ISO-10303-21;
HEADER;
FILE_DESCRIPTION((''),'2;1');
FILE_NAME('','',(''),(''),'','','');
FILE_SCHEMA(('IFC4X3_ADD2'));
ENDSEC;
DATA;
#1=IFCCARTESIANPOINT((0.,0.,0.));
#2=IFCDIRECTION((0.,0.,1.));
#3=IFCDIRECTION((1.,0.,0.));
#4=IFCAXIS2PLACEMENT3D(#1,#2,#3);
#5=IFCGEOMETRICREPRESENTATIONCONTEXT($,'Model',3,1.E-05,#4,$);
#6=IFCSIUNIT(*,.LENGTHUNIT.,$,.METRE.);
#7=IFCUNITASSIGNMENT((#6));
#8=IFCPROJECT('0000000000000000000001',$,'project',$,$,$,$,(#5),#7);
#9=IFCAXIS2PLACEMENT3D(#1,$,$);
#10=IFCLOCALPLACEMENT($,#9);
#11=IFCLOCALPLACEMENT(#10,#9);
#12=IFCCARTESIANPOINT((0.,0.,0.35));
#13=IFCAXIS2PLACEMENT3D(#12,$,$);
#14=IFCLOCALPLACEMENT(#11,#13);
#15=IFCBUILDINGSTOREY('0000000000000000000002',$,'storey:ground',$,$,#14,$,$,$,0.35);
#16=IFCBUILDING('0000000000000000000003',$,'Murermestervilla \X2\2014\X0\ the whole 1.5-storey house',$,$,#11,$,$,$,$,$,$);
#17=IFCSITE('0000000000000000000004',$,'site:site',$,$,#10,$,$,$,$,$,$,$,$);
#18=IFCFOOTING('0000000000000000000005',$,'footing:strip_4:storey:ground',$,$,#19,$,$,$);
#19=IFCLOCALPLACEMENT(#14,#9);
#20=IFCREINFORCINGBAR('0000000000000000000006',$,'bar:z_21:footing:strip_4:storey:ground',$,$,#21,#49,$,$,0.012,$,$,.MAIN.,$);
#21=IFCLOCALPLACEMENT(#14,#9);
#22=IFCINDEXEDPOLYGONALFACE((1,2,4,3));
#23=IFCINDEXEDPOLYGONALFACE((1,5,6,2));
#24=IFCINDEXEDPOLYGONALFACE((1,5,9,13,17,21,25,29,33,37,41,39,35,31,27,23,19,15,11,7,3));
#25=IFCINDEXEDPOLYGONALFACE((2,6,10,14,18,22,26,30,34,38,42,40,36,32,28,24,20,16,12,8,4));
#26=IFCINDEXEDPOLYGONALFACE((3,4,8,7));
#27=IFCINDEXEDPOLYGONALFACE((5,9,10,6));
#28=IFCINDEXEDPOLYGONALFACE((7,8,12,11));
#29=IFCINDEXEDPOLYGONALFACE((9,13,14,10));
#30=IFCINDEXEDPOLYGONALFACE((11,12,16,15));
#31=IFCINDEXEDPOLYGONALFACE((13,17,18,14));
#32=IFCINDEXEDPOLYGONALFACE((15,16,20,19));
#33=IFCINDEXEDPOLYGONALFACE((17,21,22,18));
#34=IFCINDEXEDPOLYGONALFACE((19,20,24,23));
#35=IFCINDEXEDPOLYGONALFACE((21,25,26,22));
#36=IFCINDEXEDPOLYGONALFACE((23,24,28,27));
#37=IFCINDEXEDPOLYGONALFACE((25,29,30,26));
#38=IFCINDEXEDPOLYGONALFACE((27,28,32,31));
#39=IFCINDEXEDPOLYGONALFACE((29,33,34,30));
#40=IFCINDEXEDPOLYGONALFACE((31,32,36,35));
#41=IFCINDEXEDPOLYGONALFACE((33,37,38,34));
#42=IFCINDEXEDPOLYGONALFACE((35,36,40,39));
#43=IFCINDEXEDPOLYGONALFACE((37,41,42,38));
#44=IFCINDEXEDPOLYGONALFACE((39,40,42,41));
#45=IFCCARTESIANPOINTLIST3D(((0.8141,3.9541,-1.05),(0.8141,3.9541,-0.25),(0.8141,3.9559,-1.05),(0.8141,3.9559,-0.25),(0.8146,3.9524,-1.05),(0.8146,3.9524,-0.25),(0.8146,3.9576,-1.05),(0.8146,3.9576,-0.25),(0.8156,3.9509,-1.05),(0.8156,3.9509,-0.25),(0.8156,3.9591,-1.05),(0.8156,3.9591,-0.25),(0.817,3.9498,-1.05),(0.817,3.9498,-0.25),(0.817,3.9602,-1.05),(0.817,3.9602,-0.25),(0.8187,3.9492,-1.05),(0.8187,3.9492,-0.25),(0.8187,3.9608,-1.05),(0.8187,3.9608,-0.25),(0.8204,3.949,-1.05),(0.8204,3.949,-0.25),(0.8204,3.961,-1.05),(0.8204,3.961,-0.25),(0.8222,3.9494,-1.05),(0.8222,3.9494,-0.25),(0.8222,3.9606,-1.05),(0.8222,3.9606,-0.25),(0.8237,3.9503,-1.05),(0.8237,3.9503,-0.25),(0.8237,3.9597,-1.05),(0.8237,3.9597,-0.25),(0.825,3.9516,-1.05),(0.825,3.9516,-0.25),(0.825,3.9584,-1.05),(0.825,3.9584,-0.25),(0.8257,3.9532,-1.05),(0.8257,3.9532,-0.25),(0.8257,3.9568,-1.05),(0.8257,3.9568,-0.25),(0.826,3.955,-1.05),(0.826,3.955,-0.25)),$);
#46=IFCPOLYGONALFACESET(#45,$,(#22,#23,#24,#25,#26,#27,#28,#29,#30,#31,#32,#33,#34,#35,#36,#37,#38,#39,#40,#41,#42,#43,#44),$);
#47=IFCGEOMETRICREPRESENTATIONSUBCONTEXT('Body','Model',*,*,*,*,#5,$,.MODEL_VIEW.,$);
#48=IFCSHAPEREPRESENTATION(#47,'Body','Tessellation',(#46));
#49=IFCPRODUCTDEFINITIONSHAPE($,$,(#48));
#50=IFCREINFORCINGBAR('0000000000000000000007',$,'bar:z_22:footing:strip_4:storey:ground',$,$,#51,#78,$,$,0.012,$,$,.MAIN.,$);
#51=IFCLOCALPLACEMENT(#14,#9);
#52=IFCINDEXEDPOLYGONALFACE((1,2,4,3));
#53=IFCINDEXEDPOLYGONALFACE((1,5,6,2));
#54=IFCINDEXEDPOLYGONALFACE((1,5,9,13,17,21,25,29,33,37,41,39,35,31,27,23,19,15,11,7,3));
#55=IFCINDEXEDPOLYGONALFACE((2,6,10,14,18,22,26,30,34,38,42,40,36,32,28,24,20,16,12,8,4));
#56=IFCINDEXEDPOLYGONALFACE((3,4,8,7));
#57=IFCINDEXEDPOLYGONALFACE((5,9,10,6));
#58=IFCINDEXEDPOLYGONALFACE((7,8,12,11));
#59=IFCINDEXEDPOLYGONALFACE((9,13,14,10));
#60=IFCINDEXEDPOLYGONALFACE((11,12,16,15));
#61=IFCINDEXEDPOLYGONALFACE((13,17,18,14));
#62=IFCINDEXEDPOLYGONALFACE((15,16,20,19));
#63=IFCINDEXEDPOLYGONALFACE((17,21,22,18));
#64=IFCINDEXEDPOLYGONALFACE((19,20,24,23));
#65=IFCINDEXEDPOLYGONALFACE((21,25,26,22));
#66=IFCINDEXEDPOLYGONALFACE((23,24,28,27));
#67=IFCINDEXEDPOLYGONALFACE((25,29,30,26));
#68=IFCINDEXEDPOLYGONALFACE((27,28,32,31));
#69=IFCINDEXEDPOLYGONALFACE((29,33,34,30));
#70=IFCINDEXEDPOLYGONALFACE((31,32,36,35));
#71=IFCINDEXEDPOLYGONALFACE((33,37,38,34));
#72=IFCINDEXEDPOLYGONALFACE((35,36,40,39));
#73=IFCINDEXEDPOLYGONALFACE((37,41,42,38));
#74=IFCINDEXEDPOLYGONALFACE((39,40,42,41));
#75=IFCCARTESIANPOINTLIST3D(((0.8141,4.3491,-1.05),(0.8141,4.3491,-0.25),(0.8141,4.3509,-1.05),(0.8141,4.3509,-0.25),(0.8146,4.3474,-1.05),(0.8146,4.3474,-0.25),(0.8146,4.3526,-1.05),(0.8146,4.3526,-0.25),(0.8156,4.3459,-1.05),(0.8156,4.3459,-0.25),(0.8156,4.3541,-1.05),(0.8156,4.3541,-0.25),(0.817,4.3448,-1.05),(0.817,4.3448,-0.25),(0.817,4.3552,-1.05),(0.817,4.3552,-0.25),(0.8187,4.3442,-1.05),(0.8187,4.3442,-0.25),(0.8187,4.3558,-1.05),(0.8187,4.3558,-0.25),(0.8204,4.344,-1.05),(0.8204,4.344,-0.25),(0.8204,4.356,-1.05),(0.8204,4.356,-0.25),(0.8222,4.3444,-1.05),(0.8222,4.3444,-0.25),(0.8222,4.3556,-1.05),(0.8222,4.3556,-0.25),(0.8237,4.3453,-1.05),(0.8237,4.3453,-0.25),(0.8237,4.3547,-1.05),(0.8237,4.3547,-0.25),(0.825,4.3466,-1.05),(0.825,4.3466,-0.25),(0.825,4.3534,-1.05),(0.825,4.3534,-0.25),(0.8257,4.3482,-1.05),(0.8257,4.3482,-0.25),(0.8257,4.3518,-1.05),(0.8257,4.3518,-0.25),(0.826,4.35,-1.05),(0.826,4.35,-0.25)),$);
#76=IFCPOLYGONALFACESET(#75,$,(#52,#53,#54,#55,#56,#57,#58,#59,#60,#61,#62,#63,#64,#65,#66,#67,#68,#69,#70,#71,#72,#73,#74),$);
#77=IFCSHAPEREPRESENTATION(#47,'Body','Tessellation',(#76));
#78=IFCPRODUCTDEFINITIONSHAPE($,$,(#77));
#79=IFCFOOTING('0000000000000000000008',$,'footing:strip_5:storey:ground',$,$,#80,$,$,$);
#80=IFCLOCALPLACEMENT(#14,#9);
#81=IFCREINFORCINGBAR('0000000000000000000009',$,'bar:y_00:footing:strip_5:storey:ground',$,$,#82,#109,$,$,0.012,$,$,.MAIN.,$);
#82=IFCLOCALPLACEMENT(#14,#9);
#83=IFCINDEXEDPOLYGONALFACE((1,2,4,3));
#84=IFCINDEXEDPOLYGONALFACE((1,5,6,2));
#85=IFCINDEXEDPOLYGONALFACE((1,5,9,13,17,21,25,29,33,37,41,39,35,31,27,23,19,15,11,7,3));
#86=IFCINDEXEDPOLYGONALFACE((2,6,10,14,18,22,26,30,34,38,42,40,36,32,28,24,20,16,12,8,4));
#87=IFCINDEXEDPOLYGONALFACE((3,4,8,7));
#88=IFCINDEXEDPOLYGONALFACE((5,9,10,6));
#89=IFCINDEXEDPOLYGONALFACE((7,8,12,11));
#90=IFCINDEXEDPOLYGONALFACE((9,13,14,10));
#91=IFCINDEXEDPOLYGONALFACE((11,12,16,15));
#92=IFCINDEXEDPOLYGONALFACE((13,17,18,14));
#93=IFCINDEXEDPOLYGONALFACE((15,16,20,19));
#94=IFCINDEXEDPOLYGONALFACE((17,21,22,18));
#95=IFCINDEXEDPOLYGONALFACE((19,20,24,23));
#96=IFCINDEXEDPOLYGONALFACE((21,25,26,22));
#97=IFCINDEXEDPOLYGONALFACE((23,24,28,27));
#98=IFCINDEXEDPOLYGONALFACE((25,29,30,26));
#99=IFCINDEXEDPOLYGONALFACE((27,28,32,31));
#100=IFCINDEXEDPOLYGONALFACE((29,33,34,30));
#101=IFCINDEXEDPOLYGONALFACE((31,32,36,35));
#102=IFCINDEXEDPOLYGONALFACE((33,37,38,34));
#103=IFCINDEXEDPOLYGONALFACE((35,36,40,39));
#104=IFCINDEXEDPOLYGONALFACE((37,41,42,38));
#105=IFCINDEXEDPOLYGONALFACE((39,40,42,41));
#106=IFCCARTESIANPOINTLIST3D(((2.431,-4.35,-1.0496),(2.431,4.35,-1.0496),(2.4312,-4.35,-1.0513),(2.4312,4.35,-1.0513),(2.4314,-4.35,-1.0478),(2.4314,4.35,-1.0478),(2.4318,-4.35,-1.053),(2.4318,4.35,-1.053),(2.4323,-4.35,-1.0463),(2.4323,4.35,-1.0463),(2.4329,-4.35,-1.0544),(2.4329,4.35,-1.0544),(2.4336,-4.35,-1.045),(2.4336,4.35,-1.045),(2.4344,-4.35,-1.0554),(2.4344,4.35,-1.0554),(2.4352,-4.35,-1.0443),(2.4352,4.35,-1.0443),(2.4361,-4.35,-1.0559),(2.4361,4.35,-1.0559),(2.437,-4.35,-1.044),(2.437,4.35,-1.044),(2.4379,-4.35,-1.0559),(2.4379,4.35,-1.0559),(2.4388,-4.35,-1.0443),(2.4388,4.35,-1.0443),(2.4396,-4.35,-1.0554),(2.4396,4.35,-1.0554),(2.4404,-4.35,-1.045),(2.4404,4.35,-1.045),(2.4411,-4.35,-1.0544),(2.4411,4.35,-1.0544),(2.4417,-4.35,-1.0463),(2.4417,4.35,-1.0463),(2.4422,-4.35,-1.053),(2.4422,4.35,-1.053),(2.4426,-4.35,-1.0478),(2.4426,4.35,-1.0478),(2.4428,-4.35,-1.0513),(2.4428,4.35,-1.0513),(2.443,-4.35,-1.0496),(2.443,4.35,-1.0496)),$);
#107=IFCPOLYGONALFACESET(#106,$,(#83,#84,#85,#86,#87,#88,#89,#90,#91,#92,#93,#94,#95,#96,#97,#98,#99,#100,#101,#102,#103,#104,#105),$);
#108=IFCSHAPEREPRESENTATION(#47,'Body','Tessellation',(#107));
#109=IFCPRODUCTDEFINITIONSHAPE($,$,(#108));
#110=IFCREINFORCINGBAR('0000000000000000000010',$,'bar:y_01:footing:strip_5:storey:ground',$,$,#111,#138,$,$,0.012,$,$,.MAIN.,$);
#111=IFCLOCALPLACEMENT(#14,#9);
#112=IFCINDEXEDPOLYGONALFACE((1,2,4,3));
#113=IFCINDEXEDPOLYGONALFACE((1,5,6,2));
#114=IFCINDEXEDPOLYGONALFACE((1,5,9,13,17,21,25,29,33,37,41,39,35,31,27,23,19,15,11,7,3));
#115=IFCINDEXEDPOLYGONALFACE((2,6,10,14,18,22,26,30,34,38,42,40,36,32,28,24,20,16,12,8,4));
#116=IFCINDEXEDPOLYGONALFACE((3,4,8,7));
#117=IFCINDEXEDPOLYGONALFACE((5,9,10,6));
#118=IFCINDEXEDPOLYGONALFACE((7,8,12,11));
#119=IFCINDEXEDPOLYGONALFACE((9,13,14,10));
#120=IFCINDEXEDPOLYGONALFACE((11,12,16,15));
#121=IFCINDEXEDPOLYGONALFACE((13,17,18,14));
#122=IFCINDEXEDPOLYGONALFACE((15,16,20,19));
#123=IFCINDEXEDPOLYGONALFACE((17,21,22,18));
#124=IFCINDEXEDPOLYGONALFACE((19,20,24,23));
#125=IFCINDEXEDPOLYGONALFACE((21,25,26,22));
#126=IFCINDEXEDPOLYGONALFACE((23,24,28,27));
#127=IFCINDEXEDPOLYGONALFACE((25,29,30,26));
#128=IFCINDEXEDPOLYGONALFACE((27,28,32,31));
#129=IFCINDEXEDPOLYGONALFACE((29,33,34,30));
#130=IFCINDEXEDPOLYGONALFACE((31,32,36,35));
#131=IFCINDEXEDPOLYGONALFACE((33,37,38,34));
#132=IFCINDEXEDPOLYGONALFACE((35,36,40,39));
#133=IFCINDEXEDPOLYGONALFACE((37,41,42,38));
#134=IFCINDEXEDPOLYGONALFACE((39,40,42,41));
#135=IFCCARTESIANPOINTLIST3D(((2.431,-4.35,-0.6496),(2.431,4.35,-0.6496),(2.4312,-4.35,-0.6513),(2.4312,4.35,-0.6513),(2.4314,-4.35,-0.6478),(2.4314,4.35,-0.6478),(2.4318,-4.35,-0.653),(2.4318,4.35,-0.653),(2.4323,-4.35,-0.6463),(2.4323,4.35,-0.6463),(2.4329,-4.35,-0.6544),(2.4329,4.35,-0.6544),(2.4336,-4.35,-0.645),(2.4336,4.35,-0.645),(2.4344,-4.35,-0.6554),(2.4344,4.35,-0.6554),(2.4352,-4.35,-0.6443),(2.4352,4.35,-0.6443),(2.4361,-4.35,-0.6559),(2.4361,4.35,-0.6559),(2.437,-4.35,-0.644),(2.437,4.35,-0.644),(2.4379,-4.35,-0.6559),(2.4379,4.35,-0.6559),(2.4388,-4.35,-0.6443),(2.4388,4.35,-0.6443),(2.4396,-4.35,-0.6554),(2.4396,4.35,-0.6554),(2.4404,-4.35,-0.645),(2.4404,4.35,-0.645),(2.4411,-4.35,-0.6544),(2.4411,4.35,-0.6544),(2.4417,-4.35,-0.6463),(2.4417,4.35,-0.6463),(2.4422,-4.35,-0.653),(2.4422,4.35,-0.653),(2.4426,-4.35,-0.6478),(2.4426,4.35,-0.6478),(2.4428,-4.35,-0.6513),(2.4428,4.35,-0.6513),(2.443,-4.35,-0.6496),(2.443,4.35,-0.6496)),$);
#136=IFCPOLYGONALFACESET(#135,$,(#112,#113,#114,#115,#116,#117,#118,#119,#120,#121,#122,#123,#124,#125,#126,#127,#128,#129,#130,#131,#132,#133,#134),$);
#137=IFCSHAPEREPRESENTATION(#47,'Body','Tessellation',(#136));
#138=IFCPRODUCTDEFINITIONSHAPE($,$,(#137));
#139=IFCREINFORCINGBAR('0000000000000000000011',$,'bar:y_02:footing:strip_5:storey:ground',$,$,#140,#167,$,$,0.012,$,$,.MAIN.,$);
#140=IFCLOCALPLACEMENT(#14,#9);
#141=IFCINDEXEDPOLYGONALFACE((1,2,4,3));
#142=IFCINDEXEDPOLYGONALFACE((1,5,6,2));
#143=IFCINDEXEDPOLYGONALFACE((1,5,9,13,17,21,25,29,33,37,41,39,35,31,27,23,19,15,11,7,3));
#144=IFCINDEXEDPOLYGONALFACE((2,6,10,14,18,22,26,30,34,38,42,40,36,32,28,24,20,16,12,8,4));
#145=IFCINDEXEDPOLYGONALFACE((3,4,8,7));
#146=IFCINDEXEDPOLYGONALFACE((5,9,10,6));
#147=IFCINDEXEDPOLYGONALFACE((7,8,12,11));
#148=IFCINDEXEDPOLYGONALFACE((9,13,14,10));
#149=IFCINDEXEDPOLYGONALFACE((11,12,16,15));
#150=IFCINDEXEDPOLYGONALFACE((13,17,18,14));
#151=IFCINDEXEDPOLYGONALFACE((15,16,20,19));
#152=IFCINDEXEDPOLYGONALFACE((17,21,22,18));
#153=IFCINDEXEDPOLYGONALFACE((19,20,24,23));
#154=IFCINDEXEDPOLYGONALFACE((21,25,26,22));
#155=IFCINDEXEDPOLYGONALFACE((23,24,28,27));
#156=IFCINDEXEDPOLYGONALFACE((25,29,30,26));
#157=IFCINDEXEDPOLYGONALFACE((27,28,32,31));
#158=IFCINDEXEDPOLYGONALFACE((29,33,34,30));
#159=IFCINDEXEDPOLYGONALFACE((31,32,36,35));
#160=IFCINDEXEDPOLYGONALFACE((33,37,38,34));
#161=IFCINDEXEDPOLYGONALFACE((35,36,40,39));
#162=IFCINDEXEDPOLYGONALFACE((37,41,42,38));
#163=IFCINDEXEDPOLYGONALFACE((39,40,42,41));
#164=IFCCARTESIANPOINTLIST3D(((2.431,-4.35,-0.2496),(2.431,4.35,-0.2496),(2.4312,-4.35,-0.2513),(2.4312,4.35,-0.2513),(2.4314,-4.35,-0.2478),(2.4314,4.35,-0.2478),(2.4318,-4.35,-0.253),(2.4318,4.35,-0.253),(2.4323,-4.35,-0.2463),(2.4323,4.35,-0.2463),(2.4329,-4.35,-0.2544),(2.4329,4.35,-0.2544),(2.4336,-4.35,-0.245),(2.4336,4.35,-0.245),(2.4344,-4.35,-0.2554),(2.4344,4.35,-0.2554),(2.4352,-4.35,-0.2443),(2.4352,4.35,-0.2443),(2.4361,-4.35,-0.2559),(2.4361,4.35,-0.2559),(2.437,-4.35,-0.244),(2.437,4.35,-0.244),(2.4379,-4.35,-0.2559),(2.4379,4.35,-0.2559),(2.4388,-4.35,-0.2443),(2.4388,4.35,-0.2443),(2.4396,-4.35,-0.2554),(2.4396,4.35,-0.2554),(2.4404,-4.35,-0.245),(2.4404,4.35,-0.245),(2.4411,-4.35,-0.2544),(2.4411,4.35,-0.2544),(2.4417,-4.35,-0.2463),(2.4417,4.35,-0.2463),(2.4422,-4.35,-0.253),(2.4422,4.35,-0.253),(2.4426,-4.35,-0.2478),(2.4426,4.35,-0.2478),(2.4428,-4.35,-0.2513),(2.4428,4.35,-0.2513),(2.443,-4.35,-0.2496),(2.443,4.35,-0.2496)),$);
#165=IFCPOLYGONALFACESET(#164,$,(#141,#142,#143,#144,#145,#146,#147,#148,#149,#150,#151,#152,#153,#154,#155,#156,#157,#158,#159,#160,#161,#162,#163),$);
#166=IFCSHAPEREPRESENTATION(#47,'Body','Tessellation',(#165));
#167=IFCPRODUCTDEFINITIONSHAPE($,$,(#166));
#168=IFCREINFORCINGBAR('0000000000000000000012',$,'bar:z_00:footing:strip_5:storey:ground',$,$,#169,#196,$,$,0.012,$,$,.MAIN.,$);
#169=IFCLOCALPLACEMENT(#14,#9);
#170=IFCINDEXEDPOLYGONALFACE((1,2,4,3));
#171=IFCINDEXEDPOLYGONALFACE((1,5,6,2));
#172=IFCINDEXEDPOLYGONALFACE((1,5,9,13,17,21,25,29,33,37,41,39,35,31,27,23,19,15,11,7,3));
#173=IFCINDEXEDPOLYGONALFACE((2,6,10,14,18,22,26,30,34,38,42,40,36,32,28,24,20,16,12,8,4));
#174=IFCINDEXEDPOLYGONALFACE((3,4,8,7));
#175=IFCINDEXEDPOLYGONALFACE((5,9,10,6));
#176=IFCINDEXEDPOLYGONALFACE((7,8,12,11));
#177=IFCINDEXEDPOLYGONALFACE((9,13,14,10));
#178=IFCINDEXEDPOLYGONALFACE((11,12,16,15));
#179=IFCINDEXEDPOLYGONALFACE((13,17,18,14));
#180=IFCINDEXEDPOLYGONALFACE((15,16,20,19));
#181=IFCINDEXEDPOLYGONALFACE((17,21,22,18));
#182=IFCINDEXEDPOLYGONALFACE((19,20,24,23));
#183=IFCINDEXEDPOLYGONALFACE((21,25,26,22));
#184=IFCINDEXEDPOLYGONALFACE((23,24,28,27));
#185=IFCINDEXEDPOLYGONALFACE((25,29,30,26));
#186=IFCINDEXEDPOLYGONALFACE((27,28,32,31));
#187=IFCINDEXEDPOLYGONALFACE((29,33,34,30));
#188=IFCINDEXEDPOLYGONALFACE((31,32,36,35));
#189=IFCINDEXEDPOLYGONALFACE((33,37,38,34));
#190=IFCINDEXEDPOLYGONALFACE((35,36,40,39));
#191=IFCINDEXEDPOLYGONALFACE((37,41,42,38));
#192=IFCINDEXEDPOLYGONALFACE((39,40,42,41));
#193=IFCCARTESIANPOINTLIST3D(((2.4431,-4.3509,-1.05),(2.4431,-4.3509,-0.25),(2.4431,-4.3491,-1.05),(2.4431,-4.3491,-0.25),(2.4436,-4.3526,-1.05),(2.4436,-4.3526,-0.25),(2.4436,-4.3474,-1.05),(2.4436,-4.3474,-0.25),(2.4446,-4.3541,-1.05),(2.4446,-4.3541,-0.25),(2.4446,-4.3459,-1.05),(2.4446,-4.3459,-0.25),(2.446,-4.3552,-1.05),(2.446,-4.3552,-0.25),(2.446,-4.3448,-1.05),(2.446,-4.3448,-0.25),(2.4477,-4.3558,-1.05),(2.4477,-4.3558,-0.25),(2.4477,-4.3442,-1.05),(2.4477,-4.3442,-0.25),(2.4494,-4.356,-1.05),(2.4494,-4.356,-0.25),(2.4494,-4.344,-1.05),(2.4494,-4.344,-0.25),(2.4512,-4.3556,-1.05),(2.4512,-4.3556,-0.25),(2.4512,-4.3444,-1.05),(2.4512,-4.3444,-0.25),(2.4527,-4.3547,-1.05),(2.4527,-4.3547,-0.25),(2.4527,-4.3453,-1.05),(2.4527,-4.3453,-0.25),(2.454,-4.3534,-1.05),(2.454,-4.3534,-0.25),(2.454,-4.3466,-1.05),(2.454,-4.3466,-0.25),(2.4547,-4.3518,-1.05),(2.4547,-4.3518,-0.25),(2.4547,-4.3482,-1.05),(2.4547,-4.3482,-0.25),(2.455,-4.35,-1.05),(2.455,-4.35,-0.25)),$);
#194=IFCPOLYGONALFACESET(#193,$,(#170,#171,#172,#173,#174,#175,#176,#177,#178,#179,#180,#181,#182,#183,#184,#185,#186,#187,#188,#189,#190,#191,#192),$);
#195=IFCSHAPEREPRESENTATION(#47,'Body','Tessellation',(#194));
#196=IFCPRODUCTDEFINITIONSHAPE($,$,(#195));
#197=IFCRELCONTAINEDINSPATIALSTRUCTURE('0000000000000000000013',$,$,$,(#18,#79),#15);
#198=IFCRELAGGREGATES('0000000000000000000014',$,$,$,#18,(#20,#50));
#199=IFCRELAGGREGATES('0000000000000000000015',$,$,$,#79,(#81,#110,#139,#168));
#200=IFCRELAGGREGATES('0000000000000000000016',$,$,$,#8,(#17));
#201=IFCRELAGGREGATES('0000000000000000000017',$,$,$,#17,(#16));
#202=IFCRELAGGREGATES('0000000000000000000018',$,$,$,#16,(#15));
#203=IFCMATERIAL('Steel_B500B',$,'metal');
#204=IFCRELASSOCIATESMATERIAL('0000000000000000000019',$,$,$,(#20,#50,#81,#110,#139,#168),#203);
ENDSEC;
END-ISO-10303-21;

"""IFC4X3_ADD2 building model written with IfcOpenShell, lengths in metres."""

from ifc_helpers import new_model, entity, si_unit, frame, origin, origin_with_axes, place, context, subcontext, project, spatial, material, element, aggregate, save


model = new_model("IFC4X3_ADD2")

# Units and contexts
model_context = context("Model", 3, precision=1e-05, world=origin_with_axes())
body_context = subcontext(model_context, "Body", "Model", "MODEL_VIEW")
ifc_project = project(units=[si_unit("LENGTHUNIT", "METRE")], contexts=[model_context])

# Site, building, storey
placement_1 = place(None, origin())
site = spatial("IfcSite", under=ifc_project, at=placement_1, Name="site:site")
building_placement = place(placement_1, origin())
building = spatial("IfcBuilding", under=site, at=building_placement, Name="Murermestervilla — the whole 1.5-storey house")
storey_placement = place(building_placement, frame((0.0, 0.0, 0.35)))
storey = spatial("IfcBuildingStorey", under=building, at=storey_placement, Name="storey:ground", Elevation=0.35)

# Footings, reinforcing bars
placement_2 = place(storey_placement, frame((0.0, 0.0, -0.35)))
footing_1 = element("IfcFooting", 1, at=placement_2, inside=storey, Name="footing:strip_4:storey:ground")
ifc_material = material(Name="Steel_B500B", Category="metal")
reinforcing_bar_1 = element("IfcReinforcingBar", 2, at=placement_1, material=ifc_material, Name="bar:z_21:footing:strip_4:storey:ground", NominalDiameter=0.012, PredefinedType="MAIN", context=body_context, shape_type="AdvancedSweptSolid", body=[
    entity("IfcSweptDiskSolid", entity("IfcPolyline", [entity("IfcCartesianPoint", [0.82, 3.955, -0.7]), entity("IfcCartesianPoint", [0.82, 3.955, 0.1])]), 0.006),
])
reinforcing_bar_2 = element("IfcReinforcingBar", 3, at=placement_1, material=ifc_material, Name="bar:z_22:footing:strip_4:storey:ground", NominalDiameter=0.012, PredefinedType="MAIN", context=body_context, shape_type="AdvancedSweptSolid", body=[
    entity("IfcSweptDiskSolid", entity("IfcPolyline", [entity("IfcCartesianPoint", [0.82, 4.35, -0.7]), entity("IfcCartesianPoint", [0.82, 4.35, 0.1])]), 0.006),
])
aggregate(footing_1, [reinforcing_bar_1, reinforcing_bar_2])
footing_2 = element("IfcFooting", 4, at=placement_2, inside=storey, Name="footing:strip_5:storey:ground")
reinforcing_bar_3 = element("IfcReinforcingBar", 5, at=placement_1, material=ifc_material, Name="bar:y_00:footing:strip_5:storey:ground", NominalDiameter=0.012, PredefinedType="MAIN", context=body_context, shape_type="AdvancedSweptSolid", body=[
    entity("IfcSweptDiskSolid", entity("IfcPolyline", [entity("IfcCartesianPoint", [2.437, -4.35, -0.7]), entity("IfcCartesianPoint", [2.437, 4.35, -0.7])]), 0.006),
])
reinforcing_bar_4 = element("IfcReinforcingBar", 6, at=placement_1, material=ifc_material, Name="bar:y_01:footing:strip_5:storey:ground", NominalDiameter=0.012, PredefinedType="MAIN", context=body_context, shape_type="AdvancedSweptSolid", body=[
    entity("IfcSweptDiskSolid", entity("IfcPolyline", [entity("IfcCartesianPoint", [2.437, -4.35, -0.3]), entity("IfcCartesianPoint", [2.437, 4.35, -0.3])]), 0.006),
])
reinforcing_bar_5 = element("IfcReinforcingBar", 7, at=placement_1, material=ifc_material, Name="bar:y_02:footing:strip_5:storey:ground", NominalDiameter=0.012, PredefinedType="MAIN", context=body_context, shape_type="AdvancedSweptSolid", body=[
    entity("IfcSweptDiskSolid", entity("IfcPolyline", [entity("IfcCartesianPoint", [2.437, -4.35, 0.1]), entity("IfcCartesianPoint", [2.437, 4.35, 0.1])]), 0.006),
])
reinforcing_bar_6 = element("IfcReinforcingBar", 8, at=placement_1, material=ifc_material, Name="bar:z_00:footing:strip_5:storey:ground", NominalDiameter=0.012, PredefinedType="MAIN", context=body_context, shape_type="AdvancedSweptSolid", body=[
    entity("IfcSweptDiskSolid", entity("IfcPolyline", [entity("IfcCartesianPoint", [2.449, -4.35, -0.7]), entity("IfcCartesianPoint", [2.449, -4.35, 0.1])]), 0.006),
])
aggregate(footing_2, [reinforcing_bar_3, reinforcing_bar_4, reinforcing_bar_5, reinforcing_bar_6])

save(model, "model.ifc")
